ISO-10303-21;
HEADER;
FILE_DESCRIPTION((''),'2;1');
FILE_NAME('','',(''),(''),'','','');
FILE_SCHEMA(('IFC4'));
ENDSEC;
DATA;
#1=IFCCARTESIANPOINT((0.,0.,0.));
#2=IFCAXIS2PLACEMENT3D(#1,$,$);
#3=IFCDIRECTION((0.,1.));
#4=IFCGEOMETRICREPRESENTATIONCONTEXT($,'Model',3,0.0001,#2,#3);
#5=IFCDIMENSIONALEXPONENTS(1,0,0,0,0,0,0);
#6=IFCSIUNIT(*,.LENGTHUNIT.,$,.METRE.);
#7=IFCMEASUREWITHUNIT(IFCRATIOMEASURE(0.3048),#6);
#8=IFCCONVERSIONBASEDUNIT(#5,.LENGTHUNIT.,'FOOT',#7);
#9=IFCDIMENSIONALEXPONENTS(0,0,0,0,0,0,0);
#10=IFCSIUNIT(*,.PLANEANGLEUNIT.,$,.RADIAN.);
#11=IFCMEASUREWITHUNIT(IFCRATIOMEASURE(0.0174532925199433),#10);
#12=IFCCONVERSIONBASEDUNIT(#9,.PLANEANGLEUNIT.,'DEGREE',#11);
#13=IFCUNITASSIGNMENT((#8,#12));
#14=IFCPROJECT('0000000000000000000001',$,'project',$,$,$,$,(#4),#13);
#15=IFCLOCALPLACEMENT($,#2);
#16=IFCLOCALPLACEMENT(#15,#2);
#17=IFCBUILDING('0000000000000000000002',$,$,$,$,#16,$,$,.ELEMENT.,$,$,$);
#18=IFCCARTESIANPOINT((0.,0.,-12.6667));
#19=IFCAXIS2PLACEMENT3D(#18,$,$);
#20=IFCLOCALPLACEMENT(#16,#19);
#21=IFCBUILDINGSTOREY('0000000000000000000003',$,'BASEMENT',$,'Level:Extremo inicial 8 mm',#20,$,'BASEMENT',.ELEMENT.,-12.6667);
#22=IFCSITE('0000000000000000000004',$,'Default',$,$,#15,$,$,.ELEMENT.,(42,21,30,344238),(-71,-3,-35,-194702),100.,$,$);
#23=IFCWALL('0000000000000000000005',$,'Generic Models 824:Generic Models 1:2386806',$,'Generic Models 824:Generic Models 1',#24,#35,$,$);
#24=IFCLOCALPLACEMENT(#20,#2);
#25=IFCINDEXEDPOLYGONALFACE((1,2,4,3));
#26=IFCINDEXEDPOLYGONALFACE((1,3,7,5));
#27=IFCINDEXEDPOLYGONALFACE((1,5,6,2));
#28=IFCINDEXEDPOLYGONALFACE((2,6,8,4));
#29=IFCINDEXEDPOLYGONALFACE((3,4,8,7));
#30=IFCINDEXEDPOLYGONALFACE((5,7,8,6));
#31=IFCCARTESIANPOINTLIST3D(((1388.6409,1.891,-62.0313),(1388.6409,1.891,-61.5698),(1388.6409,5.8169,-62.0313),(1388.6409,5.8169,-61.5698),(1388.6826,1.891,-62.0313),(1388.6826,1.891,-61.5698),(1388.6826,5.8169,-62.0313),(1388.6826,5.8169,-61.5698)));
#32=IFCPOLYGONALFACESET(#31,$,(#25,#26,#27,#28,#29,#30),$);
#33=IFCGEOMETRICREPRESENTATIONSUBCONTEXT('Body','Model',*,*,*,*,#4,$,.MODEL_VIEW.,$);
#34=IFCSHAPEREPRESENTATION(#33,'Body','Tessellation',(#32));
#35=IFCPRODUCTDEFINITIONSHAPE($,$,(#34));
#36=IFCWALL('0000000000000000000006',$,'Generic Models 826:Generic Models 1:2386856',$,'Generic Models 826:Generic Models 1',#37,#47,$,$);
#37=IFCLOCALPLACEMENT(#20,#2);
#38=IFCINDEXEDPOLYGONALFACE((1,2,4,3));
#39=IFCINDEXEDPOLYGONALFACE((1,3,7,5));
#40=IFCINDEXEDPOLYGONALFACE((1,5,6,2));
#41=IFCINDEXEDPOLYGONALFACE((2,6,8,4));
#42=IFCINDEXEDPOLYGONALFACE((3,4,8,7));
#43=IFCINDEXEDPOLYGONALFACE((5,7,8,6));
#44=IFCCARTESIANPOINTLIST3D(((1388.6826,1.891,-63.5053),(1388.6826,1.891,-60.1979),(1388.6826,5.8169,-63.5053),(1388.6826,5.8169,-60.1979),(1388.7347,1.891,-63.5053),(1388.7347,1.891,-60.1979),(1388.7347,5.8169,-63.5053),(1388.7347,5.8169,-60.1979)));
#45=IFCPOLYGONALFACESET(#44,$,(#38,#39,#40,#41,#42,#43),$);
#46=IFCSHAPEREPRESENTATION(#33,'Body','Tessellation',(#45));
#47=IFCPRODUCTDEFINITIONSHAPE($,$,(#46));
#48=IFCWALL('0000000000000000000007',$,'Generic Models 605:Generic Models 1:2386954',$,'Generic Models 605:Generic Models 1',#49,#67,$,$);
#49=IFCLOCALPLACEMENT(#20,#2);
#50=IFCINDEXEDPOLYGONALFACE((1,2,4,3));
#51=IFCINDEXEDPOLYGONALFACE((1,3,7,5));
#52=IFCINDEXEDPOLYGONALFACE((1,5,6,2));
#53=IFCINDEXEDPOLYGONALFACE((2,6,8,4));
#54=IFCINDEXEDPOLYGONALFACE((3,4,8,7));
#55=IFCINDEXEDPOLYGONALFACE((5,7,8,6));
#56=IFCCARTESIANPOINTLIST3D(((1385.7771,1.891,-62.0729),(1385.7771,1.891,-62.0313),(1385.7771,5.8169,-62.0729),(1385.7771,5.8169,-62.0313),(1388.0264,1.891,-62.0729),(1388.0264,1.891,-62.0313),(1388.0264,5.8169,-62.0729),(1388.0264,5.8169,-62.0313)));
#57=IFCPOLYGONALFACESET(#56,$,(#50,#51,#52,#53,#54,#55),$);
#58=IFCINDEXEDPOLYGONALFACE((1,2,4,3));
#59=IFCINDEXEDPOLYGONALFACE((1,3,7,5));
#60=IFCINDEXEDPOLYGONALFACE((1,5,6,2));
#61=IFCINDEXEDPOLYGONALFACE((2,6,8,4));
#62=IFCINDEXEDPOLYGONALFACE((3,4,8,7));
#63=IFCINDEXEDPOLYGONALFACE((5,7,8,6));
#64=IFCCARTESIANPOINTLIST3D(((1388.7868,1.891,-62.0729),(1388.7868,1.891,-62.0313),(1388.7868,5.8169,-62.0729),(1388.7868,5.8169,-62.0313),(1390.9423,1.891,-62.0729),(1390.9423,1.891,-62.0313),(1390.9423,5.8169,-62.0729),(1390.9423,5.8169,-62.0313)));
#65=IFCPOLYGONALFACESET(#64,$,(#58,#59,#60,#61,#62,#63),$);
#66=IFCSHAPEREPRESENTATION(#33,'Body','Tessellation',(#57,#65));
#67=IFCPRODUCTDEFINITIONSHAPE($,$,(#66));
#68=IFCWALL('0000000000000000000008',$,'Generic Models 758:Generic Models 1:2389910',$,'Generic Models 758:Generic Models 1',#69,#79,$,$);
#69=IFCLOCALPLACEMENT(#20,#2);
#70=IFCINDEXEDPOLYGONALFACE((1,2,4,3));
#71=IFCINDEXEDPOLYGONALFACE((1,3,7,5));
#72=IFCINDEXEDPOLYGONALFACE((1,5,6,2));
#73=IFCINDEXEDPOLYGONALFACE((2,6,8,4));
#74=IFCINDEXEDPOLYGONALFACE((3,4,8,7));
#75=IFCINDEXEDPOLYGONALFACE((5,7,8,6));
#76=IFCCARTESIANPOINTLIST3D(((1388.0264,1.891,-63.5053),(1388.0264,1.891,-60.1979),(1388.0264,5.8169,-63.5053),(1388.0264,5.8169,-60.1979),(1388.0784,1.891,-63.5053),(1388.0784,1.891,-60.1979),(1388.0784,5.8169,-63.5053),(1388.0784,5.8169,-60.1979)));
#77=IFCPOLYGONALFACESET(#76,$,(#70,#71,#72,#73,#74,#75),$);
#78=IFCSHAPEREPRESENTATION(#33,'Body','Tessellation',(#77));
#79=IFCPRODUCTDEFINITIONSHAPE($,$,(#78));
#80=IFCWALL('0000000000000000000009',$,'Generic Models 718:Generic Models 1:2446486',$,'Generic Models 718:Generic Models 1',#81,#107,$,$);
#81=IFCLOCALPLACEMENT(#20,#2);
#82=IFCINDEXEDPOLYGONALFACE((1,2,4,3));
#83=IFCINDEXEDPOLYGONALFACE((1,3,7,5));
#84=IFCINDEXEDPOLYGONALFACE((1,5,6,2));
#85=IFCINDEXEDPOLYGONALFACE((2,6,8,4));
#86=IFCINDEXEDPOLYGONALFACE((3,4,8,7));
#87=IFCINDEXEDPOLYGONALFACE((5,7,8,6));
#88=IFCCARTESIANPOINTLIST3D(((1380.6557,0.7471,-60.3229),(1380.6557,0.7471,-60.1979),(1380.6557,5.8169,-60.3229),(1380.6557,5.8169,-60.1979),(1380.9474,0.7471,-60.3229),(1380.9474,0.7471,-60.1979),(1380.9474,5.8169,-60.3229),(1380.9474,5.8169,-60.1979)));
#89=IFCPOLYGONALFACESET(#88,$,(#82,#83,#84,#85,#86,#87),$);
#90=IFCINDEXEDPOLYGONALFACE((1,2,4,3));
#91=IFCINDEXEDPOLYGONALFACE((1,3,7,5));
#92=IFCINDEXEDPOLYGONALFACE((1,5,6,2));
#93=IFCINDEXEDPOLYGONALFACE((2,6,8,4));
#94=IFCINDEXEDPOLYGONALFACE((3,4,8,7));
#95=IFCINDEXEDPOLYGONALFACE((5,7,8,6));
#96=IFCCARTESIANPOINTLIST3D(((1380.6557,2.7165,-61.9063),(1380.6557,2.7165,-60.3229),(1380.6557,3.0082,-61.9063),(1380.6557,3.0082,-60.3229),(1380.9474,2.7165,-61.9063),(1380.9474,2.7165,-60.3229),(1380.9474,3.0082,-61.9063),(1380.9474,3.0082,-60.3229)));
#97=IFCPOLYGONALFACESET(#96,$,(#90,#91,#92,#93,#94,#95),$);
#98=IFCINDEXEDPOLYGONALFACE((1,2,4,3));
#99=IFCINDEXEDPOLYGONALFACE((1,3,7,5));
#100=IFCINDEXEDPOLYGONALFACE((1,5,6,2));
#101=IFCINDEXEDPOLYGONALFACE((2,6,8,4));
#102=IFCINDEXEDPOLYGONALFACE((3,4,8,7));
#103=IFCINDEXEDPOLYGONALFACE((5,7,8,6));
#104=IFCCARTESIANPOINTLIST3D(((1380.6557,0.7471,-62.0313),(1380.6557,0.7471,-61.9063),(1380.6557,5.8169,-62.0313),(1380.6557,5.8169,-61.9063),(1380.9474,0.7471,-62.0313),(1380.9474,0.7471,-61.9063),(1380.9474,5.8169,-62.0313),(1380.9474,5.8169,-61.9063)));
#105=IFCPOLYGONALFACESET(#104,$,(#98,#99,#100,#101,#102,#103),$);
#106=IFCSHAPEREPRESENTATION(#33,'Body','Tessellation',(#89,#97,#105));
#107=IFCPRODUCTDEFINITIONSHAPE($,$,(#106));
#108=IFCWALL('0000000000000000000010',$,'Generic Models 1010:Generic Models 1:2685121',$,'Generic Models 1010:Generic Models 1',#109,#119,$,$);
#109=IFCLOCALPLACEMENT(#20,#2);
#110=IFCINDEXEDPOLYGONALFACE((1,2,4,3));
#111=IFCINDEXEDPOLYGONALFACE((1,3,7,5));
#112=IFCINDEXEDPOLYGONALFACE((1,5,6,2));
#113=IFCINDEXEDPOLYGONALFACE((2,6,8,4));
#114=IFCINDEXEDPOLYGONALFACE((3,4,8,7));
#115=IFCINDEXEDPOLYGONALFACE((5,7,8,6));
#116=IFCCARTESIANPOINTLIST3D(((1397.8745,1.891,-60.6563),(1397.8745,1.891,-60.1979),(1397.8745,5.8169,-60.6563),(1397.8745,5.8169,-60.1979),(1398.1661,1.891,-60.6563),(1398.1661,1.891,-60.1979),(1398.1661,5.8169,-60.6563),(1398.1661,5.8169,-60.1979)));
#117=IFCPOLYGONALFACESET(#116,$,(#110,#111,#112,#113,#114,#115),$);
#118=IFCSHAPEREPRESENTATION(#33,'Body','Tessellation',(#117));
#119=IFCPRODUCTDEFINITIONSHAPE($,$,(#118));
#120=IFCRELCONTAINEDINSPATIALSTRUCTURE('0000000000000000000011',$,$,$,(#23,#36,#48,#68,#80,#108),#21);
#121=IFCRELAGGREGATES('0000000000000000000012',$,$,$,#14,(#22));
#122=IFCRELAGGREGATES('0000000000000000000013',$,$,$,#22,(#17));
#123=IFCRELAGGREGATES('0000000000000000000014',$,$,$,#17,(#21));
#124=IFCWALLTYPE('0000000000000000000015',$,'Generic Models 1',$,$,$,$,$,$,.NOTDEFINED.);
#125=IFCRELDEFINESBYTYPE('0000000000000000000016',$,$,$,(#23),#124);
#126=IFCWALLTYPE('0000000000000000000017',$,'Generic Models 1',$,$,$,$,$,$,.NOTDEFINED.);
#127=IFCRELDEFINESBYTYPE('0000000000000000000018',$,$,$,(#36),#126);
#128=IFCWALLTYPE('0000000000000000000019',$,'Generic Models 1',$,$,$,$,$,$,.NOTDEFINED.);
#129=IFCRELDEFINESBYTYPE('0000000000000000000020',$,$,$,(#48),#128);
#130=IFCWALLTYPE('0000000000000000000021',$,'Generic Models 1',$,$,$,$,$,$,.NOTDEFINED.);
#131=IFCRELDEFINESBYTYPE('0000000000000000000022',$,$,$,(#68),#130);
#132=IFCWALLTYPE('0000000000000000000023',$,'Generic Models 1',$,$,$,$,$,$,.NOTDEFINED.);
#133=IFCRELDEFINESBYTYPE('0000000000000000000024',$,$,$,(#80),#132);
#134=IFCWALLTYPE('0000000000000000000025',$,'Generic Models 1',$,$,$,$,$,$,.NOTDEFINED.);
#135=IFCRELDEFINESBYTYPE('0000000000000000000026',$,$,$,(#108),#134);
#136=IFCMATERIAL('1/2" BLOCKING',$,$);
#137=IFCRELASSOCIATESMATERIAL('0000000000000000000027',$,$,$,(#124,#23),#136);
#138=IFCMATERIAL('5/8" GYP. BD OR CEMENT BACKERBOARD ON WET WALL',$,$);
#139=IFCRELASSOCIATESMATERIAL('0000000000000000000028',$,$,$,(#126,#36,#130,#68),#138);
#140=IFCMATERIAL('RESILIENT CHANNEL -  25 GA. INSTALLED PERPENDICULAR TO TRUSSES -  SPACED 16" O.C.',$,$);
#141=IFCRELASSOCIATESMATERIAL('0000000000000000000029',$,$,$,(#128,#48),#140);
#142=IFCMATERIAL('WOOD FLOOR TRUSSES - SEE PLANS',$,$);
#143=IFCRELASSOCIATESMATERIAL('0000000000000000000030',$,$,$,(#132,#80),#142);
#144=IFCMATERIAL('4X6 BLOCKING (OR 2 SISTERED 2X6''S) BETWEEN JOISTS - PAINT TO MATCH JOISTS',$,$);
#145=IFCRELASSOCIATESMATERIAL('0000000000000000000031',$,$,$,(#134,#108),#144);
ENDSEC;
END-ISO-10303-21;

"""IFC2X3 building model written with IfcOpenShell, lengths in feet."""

from ifc_helpers import new_model, entity, si_unit, converted_unit, direction, frame, frame_2d, origin, origin_2d_with_axis, place, context, subcontext, project, spatial, rectangle, extrude, material, type_object, element, save


model = new_model("IFC2X3")

# Units and contexts
model_context = context("Model", 3, precision=0.0001, world=origin(), true_north=direction((0.0, 1.0)))
body_context = subcontext(model_context, "Body", "Model", "MODEL_VIEW")
ifc_project = project(units=[converted_unit("LENGTHUNIT", "FOOT", entity("IfcRatioMeasure", 0.3048), si_unit("LENGTHUNIT", "METRE"), dimensions=[1, 0, 0, 0, 0, 0, 0]), converted_unit("PLANEANGLEUNIT", "DEGREE", entity("IfcRatioMeasure", 0.0174532925199433), si_unit("PLANEANGLEUNIT", "RADIAN"), dimensions=[0, 0, 0, 0, 0, 0, 0])], contexts=[model_context])

# Site, building, storey
site_placement = place(None, origin())
site = spatial("IfcSite", under=ifc_project, at=site_placement, Name="Default", CompositionType="ELEMENT", RefLatitude=(42, 21, 30, 344238), RefLongitude=(-71, -3, -35, -194702), RefElevation=100.0)
building_placement = place(site_placement, origin())
building = spatial("IfcBuilding", under=site, at=building_placement, CompositionType="ELEMENT")
storey_placement = place(building_placement, frame((0.0, 0.0, -12.6667)))
storey = spatial("IfcBuildingStorey", under=building, at=storey_placement, Name="BASEMENT", ObjectType="Level:Extremo inicial 8 mm", LongName="BASEMENT", CompositionType="ELEMENT", Elevation=-12.6667)

# Walls
ifc_material_1 = material(Name="RESILIENT CHANNEL -  25 GA. INSTALLED PERPENDICULAR TO TRUSSES -  SPACED 16\" O.C.")
ifc_material_2 = material(Name="5/8\" GYP. BD OR CEMENT BACKERBOARD ON WET WALL")
ifc_material_3 = material(Name="WOOD FLOOR TRUSSES - SEE PLANS")
ifc_material_4 = material(Name="1/2\" BLOCKING")
wall_type_1 = type_object("IfcWallType", Name="Generic Models 1", PredefinedType="NOTDEFINED", material=ifc_material_4)
wall_1_placement = place(storey_placement, frame((1388.6409, 1.891, -62.0313), z_axis=(0.0, 0.0, 1.0), x_axis=(0.0, 1.0, 0.0)))
element("IfcWall", 1, at=wall_1_placement, inside=storey, type_object=wall_type_1, material=ifc_material_4, Name="Generic Models 824:Generic Models 1:2386806", ObjectType="Generic Models 824:Generic Models 1", context=body_context, shape_type="SweptSolid", body=[
    extrude(rectangle(XDim=3.9258, YDim=0.0417, at=frame_2d((0.0, 0.0), x_axis=(1.0, 0.0))), frame((1.9629, -0.0208, 0.0)), (0.0, 0.0, 1.0), 0.4615),
])
wall_type_2 = type_object("IfcWallType", Name="Generic Models 1", PredefinedType="NOTDEFINED", material=ifc_material_2)
wall_2_placement = place(storey_placement, frame((1388.6826, 1.891, -63.5053), z_axis=(0.0, 0.0, 1.0), x_axis=(0.0, 1.0, 0.0)))
element("IfcWall", 2, at=wall_2_placement, inside=storey, type_object=wall_type_2, material=ifc_material_2, Name="Generic Models 826:Generic Models 1:2386856", ObjectType="Generic Models 826:Generic Models 1", context=body_context, shape_type="SweptSolid", body=[
    extrude(rectangle(XDim=3.9258, YDim=0.0521, at=frame_2d((0.0, 0.0), x_axis=(1.0, 0.0))), frame((1.9629, -0.026, 0.0)), (0.0, 0.0, 1.0), 3.3074),
])
wall_type_3 = type_object("IfcWallType", Name="Generic Models 1", PredefinedType="NOTDEFINED", material=ifc_material_1)
wall_3_placement = place(storey_placement, frame((1385.7771, 1.891, -62.0729)))
element("IfcWall", 3, at=wall_3_placement, inside=storey, type_object=wall_type_3, material=ifc_material_1, Name="Generic Models 605:Generic Models 1:2386954", ObjectType="Generic Models 605:Generic Models 1", context=body_context, shape_type="SweptSolid", body=[
    extrude(rectangle(XDim=3.9258, YDim=2.2493, at=frame_2d((0.0, 0.0), x_axis=(1.0, 0.0))), frame((1.1246, 1.9629, 0.0), z_axis=(0.0, 0.0, 1.0), x_axis=(0.0, 1.0, 0.0)), (0.0, 0.0, 1.0), 0.0417),
    extrude(rectangle(XDim=3.9258, YDim=2.1555, at=origin_2d_with_axis()), frame((4.0875, 1.9629, 0.0), z_axis=(0.0, 0.0, 1.0), x_axis=(0.0, 1.0, 0.0)), (0.0, 0.0, 1.0), 0.0417),
])
wall_type_4 = type_object("IfcWallType", Name="Generic Models 1", PredefinedType="NOTDEFINED", material=ifc_material_2)
wall_4_placement = place(storey_placement, frame((1388.0264, 1.891, -63.5053), z_axis=(0.0, 0.0, 1.0), x_axis=(0.0, 1.0, 0.0)))
element("IfcWall", 4, at=wall_4_placement, inside=storey, type_object=wall_type_4, material=ifc_material_2, Name="Generic Models 758:Generic Models 1:2389910", ObjectType="Generic Models 758:Generic Models 1", context=body_context, shape_type="SweptSolid", body=[
    extrude(rectangle(XDim=3.9258, YDim=0.0521, at=frame_2d((0.0, 0.0), x_axis=(1.0, 0.0))), frame((1.9629, -0.026, 0.0)), (0.0, 0.0, 1.0), 3.3074),
])
wall_type_5 = type_object("IfcWallType", Name="Generic Models 1", PredefinedType="NOTDEFINED", material=ifc_material_3)
wall_5_placement = place(storey_placement, frame((1380.6557, 0.7471, -62.0313), z_axis=(0.0, 0.0, 1.0), x_axis=(0.0, 1.0, 0.0)))
element("IfcWall", 5, at=wall_5_placement, inside=storey, type_object=wall_type_5, material=ifc_material_3, Name="Generic Models 718:Generic Models 1:2446486", ObjectType="Generic Models 718:Generic Models 1", context=body_context, shape_type="SweptSolid", body=[
    extrude(rectangle(XDim=5.0697, YDim=0.2917, at=frame_2d((0.0, 0.0), x_axis=(1.0, 0.0))), frame((2.5349, -0.1458, 1.7083)), (0.0, 0.0, 1.0), 0.125),
    extrude(rectangle(XDim=0.2917, YDim=0.2917, at=frame_2d((0.0, 0.0), x_axis=(1.0, 0.0))), frame((2.1152, -0.1458, 0.125)), (0.0, 0.0, 1.0), 1.5833),
    extrude(rectangle(XDim=5.0697, YDim=0.2917, at=frame_2d((0.0, 0.0), x_axis=(1.0, 0.0))), frame((2.5349, -0.1458, 0.0)), (0.0, 0.0, 1.0), 0.125),
])
ifc_material_5 = material(Name="4X6 BLOCKING (OR 2 SISTERED 2X6'S) BETWEEN JOISTS - PAINT TO MATCH JOISTS")
wall_type_6 = type_object("IfcWallType", Name="Generic Models 1", PredefinedType="NOTDEFINED", material=ifc_material_5)
wall_6_placement = place(storey_placement, frame((1397.8745, 1.891, -60.6563), z_axis=(0.0, 0.0, 1.0), x_axis=(0.0, 1.0, 0.0)))
element("IfcWall", 6, at=wall_6_placement, inside=storey, type_object=wall_type_6, material=ifc_material_5, Name="Generic Models 1010:Generic Models 1:2685121", ObjectType="Generic Models 1010:Generic Models 1", context=body_context, shape_type="SweptSolid", body=[
    extrude(rectangle(XDim=3.9258, YDim=0.2917, at=frame_2d((0.0, 0.0), x_axis=(1.0, 0.0))), frame((1.9629, -0.1458, 0.0)), (0.0, 0.0, 1.0), 0.4583),
])

save(model, "model.ifc")
